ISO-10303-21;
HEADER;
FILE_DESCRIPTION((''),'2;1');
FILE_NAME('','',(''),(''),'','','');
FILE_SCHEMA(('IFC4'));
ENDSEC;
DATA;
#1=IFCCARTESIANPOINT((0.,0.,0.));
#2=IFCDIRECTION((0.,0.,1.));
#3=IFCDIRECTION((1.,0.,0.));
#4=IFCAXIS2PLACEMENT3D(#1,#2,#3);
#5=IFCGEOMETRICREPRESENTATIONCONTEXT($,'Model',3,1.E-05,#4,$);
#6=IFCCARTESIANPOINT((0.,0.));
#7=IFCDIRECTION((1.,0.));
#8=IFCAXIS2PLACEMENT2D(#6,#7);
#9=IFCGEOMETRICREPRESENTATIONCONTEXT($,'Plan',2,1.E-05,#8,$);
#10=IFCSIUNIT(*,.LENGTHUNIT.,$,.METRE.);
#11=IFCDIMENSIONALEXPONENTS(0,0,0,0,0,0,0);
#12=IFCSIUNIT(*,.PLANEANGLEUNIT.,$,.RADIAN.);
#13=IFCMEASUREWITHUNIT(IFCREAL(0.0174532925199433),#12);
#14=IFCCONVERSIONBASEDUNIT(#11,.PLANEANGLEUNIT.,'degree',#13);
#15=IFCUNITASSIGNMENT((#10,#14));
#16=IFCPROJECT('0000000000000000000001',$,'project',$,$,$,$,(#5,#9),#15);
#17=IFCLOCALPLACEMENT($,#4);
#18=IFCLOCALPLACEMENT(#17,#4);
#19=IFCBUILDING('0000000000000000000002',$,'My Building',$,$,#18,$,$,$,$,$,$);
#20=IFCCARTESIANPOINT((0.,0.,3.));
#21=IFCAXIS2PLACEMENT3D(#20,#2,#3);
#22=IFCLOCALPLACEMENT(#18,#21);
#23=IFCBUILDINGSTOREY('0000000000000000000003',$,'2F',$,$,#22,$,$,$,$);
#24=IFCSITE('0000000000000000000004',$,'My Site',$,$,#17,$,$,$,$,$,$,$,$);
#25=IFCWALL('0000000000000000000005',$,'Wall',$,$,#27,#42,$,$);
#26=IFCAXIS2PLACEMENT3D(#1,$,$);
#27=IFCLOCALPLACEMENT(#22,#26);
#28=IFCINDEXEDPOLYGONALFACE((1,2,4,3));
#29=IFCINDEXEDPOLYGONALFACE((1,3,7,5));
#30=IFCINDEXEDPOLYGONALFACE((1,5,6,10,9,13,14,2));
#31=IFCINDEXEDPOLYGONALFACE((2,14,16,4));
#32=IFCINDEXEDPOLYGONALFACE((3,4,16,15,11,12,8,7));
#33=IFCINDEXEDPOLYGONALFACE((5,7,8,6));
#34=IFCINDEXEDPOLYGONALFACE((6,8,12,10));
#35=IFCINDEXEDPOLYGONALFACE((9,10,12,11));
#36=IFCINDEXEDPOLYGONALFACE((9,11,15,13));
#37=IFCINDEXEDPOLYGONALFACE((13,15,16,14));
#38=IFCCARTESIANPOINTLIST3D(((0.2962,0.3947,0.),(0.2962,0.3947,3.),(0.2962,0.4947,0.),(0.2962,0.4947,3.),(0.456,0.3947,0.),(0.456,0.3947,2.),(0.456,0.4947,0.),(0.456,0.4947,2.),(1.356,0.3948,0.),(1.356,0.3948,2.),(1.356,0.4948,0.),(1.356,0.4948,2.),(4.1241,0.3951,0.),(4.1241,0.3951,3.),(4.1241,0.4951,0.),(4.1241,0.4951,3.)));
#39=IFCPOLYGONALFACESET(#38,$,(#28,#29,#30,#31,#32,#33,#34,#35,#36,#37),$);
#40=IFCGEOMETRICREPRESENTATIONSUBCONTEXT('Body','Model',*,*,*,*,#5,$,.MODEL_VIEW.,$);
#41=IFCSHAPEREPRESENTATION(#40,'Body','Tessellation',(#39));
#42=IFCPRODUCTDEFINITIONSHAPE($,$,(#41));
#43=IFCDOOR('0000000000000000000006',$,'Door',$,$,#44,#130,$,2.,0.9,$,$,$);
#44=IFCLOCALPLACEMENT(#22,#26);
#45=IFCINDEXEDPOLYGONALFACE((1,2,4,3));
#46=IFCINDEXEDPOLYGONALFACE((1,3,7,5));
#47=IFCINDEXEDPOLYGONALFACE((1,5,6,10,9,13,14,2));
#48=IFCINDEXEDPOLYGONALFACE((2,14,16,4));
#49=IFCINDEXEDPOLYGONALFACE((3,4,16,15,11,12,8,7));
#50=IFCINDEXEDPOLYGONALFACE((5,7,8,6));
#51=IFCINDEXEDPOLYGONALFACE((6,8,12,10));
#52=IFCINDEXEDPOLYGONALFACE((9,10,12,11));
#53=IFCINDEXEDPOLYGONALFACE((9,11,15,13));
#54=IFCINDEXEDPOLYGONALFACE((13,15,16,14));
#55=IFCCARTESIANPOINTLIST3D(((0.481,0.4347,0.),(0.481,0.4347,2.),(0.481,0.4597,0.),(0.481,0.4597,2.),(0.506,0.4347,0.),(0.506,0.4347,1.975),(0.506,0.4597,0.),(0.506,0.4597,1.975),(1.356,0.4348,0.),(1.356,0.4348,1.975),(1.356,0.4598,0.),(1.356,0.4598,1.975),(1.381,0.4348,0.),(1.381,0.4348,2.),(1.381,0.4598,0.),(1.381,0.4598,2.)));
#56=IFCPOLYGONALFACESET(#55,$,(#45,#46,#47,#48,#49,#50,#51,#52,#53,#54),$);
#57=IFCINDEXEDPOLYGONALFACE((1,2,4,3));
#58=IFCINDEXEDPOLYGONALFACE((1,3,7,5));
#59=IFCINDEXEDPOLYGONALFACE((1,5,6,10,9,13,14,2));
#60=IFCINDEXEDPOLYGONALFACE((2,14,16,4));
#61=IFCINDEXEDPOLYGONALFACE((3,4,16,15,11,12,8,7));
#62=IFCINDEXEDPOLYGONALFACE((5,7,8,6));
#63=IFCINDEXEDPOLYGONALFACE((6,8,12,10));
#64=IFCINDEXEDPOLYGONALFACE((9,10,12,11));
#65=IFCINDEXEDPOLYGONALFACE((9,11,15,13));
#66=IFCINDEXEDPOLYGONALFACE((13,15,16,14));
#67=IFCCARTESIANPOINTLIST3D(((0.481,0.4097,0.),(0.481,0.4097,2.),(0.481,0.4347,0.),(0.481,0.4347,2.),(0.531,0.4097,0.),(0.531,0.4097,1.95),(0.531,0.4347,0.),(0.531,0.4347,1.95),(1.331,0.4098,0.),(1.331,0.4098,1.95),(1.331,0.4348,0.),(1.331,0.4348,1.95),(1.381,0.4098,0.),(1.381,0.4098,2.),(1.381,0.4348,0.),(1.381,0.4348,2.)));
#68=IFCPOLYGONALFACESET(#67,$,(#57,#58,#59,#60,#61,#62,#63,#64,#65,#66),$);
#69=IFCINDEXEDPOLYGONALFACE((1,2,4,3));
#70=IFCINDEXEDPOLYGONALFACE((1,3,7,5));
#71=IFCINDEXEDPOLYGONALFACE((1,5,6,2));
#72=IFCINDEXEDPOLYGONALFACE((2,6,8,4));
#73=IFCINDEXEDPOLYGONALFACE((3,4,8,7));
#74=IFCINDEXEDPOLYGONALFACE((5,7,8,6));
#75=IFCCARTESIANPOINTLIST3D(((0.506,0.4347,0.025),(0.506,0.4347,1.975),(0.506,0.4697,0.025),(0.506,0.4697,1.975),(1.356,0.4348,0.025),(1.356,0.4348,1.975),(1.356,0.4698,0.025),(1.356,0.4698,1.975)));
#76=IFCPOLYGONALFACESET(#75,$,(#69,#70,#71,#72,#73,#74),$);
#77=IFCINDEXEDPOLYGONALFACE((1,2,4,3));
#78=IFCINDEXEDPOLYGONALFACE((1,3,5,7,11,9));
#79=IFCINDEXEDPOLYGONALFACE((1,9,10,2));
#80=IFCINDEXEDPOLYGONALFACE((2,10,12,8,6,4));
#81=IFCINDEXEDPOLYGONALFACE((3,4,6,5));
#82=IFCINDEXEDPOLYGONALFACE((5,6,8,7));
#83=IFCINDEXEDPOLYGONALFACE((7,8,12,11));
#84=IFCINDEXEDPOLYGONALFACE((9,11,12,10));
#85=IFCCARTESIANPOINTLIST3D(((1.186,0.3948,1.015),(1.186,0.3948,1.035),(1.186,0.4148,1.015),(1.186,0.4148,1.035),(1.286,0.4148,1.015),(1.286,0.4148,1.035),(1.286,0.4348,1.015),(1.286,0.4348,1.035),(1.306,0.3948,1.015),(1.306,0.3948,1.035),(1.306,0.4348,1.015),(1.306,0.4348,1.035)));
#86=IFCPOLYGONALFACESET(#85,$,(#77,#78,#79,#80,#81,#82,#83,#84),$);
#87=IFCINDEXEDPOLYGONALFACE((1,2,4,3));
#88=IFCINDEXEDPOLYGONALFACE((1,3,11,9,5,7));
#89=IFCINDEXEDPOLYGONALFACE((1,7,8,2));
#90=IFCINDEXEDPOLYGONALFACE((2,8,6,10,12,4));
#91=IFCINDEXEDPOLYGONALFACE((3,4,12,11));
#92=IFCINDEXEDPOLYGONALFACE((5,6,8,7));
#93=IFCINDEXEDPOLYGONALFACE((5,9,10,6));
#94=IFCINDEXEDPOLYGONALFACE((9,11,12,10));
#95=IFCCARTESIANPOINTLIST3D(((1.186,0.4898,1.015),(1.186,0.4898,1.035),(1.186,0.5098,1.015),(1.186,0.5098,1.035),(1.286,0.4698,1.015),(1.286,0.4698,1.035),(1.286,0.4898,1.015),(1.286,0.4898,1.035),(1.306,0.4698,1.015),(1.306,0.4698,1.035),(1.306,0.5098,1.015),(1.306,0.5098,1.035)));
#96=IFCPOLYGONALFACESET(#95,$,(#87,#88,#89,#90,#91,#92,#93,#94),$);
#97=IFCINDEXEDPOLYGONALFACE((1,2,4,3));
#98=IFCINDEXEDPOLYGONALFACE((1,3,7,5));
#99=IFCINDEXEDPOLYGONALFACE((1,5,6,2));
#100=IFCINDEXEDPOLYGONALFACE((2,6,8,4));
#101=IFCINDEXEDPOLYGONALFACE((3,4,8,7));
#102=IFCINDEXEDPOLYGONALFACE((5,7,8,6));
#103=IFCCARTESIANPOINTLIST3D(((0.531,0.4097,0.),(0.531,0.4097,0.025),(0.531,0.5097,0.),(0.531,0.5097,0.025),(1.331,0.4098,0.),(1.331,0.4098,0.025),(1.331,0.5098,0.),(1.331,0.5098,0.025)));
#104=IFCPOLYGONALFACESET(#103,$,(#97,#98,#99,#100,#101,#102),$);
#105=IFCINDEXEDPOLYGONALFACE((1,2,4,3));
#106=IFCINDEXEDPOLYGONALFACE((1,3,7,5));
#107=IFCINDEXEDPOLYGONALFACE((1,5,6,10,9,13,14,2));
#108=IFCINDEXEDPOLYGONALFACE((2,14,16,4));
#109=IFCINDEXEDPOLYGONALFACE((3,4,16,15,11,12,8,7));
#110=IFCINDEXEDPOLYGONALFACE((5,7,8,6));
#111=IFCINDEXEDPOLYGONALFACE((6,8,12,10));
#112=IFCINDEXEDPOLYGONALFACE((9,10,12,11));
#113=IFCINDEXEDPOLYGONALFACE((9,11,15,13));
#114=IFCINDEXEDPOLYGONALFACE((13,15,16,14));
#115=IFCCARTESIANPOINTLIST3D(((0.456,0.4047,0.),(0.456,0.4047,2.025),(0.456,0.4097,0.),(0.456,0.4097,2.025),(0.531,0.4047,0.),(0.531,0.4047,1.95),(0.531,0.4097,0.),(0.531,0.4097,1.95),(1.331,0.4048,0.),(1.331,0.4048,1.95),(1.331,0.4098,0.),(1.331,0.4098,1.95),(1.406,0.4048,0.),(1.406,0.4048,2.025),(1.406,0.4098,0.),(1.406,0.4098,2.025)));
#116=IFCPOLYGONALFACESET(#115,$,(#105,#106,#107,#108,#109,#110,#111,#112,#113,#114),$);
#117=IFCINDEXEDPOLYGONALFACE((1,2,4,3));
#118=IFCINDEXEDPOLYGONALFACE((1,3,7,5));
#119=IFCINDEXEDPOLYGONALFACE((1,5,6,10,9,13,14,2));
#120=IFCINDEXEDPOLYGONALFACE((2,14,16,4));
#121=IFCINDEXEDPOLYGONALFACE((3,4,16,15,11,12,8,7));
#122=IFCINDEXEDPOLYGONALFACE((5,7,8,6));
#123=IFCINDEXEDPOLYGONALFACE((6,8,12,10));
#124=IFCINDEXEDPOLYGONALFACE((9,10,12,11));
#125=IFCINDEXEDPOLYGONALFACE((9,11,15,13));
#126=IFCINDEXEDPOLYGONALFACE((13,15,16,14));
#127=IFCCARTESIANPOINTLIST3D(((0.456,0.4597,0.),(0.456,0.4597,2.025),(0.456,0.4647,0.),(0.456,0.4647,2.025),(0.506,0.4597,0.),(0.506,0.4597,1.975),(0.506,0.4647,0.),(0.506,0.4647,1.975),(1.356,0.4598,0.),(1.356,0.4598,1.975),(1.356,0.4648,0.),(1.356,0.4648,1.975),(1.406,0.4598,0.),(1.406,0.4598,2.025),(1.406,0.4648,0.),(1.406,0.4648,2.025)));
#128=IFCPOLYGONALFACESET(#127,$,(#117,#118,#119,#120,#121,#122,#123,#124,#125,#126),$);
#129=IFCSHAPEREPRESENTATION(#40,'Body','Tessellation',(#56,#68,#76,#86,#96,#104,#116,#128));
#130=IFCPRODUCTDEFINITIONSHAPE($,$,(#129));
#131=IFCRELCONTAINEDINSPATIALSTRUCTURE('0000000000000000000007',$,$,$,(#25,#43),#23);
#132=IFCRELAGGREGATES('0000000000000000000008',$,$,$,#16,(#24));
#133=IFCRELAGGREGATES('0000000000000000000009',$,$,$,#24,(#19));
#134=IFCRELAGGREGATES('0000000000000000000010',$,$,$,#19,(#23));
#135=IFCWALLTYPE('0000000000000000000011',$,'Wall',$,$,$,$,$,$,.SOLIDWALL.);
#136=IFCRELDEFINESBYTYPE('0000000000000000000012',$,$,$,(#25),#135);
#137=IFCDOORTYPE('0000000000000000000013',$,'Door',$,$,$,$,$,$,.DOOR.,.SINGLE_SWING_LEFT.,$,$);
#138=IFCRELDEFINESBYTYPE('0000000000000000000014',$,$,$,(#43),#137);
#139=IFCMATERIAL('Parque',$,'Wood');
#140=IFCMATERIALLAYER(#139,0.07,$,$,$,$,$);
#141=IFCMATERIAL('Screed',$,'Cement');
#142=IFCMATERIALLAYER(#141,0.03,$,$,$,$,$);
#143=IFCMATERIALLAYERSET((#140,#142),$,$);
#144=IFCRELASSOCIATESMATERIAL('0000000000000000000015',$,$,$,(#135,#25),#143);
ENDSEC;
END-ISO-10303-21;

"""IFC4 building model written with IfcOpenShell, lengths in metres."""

from ifc_helpers import new_model, entity, si_unit, converted_unit, frame, origin_with_axes, origin_2d_with_axis, place, context, subcontext, project, spatial, line, indexed_curve, outline, extrude, shape, source, transform, mapped, material, layer, layer_set, layer_usage, type_object, type_shapes, element, fill, save


model = new_model("IFC4")

# Units and contexts
model_context = context("Model", 3, precision=1e-05, world=origin_with_axes())
plan_context = context("Plan", 2, precision=1e-05, world=origin_2d_with_axis())
body_context_1 = subcontext(model_context, "Body", "Model", "MODEL_VIEW")
body_context_2 = subcontext(plan_context, "Body", "Plan", "PLAN_VIEW")
ifc_project = project(units=[si_unit("LENGTHUNIT", "METRE"), converted_unit("PLANEANGLEUNIT", "degree", entity("IfcReal", 0.0174532925199433), si_unit("PLANEANGLEUNIT", "RADIAN"), dimensions=[0, 0, 0, 0, 0, 0, 0])], contexts=[model_context, plan_context])

# Site, building, storey
site_placement = place(None, origin_with_axes())
site = spatial("IfcSite", under=ifc_project, at=site_placement, Name="My Site")
building_placement = place(site_placement, origin_with_axes())
building = spatial("IfcBuilding", under=site, at=building_placement, Name="My Building")
storey_placement = place(building_placement, frame((0.0, 0.0, 3.0), z_axis=(0.0, 0.0, 1.0), x_axis=(1.0, 0.0, 0.0)))
storey = spatial("IfcBuildingStorey", under=building, at=storey_placement, Name="2F")

# Shared definitions
ifc_material_1 = material(Name="Parque", Category="Wood")
ifc_layer_1 = layer(ifc_material_1, 0.07)
ifc_material_2 = material(Name="Screed", Category="Cement")
ifc_layer_2 = layer(ifc_material_2, 0.03)
ifc_layer_set_1 = layer_set([ifc_layer_1, ifc_layer_2])
wall_type = type_object("IfcWallType", Name="Wall", PredefinedType="SOLIDWALL", material=ifc_layer_set_1)

# Shared definitions
shared_shape_1 = source(origin_with_axes(), body_context_1, "Body", "SweptSolid", [
    extrude(outline(indexed_curve([(0.0, 0.0), (0.9, 0.0), (0.9, 2.0), (0.0, 2.0)], segments=[line(1, 2, 3, 4, 1)])), frame((0.0, -0.6, 0.0), z_axis=(0.0, -1.0, 0.0), x_axis=(1.0, 0.0, 0.0)), (0.0, 0.0, -1.0), 1.2),
])
door_type_1 = type_object("IfcDoorType", Name="Door", OperationType="SINGLE_SWING_LEFT", PredefinedType="DOOR")
shared_shape_2 = source(origin_with_axes(), body_context_1, "Body", "SweptSolid", [
    extrude(outline(indexed_curve([(0.0, 0.0), (0.0, 2.0), (0.9, 2.0), (0.9, 0.0), (0.875, 0.0), (0.875, 1.975), (0.025, 1.975), (0.025, 0.0)], segments=[line(1, 2, 3, 4, 5, 6, 7, 8, 1)])), frame((0.0, 0.025, 0.0), z_axis=(0.0, -1.0, 0.0), x_axis=(1.0, 0.0, 0.0)), (0.0, 0.0, -1.0), 0.025),
    extrude(outline(indexed_curve([(0.0, 0.0), (0.0, 2.0), (0.9, 2.0), (0.9, 0.0), (0.85, 0.0), (0.85, 1.95), (0.05, 1.95), (0.05, 0.0)], segments=[line(1, 2, 3, 4, 5, 6, 7, 8, 1)])), frame((0.0, 0.0, 0.0), z_axis=(0.0, -1.0, 0.0), x_axis=(1.0, 0.0, 0.0)), (0.0, 0.0, -1.0), 0.025),
    extrude(outline(indexed_curve([(0.0, 0.0), (0.85, 0.0), (0.85, 0.035), (0.0, 0.035)], segments=[line(1, 2, 3, 4, 1)])), frame((0.025, 0.025, 0.025), z_axis=(0.0, 0.0, 1.0), x_axis=(1.0, 0.0, 0.0)), (0.0, 0.0, 1.0), 1.95),
    extrude(outline(indexed_curve([(0.0, 0.0), (0.0, -0.04), (-0.12, -0.04), (-0.12, -0.02), (-0.02, -0.02), (-0.02, 0.0)], segments=[line(1, 2, 3, 4, 5, 6, 1)])), frame((0.825, 0.025, 1.015), z_axis=(0.0, 0.0, 1.0), x_axis=(1.0, 0.0, 0.0)), (0.0, 0.0, 1.0), 0.02),
    extrude(outline(indexed_curve([(0.0, 0.0), (0.0, 0.04), (-0.12, 0.04), (-0.12, 0.02), (-0.02, 0.02), (-0.02, 0.0)], segments=[line(1, 2, 3, 4, 5, 6, 1)])), frame((0.825, 0.06, 1.015), z_axis=(0.0, 0.0, 1.0), x_axis=(1.0, 0.0, 0.0)), (0.0, 0.0, 1.0), 0.02),
    extrude(outline(indexed_curve([(0.0, 0.0), (0.8, 0.0), (0.8, 0.1), (0.0, 0.1)], segments=[line(1, 2, 3, 4, 1)])), frame((0.05, 0.0, 0.0), z_axis=(0.0, 0.0, 1.0), x_axis=(1.0, 0.0, 0.0)), (0.0, 0.0, 1.0), 0.025),
    extrude(outline(indexed_curve([(0.0, 0.0), (0.0, 2.025), (0.95, 2.025), (0.95, 0.0), (0.875, 0.0), (0.875, 1.95), (0.075, 1.95), (0.075, 0.0)], segments=[line(1, 2, 3, 4, 5, 6, 7, 8, 1)])), frame((-0.025, -0.005, 0.0), z_axis=(0.0, -1.0, 0.0), x_axis=(1.0, 0.0, 0.0)), (0.0, 0.0, -1.0), 0.005),
    extrude(outline(indexed_curve([(0.0, 0.0), (0.0, 2.025), (0.95, 2.025), (0.95, 0.0), (0.9, 0.0), (0.9, 1.975), (0.05, 1.975), (0.05, 0.0)], segments=[line(1, 2, 3, 4, 5, 6, 7, 8, 1)])), frame((-0.025, 0.05, 0.0), z_axis=(0.0, -1.0, 0.0), x_axis=(1.0, 0.0, 0.0)), (0.0, 0.0, -1.0), 0.005),
])
shared_shape_3 = source(origin_with_axes(), body_context_2, "Body", "Curve2D", [
    entity("IfcIndexedPolyCurve", entity("IfcCartesianPointList2D", [[0.0, 0.0], [0.0, 0.05], [0.025, 0.05], [0.025, 0.025], [0.05, 0.025], [0.05, 0.0]]), [entity("IfcLineIndex", [1, 2, 3, 4, 5, 6, 1])]),
    entity("IfcIndexedPolyCurve", entity("IfcCartesianPointList2D", [[0.9, 0.0], [0.9, 0.05], [0.875, 0.05], [0.875, 0.025], [0.85, 0.025], [0.85, 0.0]]), [entity("IfcLineIndex", [1, 2, 3, 4, 5, 6, 1])]),
    entity("IfcTrimmedCurve", entity("IfcEllipse", entity("IfcAxis2Placement2D", entity("IfcCartesianPoint", [0.06, 0.05]), entity("IfcDirection", [1.0, 0.0])), 0.815, 0.85), [entity("IfcCartesianPoint", [0.875, 0.05])], [entity("IfcCartesianPoint", [0.06, 0.9])], True, "CARTESIAN"),
    entity("IfcIndexedPolyCurve", entity("IfcCartesianPointList2D", [[0.025, 0.05], [0.06, 0.05], [0.06, 0.9], [0.025, 0.9]]), [entity("IfcLineIndex", [1, 2, 3, 4, 1])]),
])
type_shapes(door_type_1, [shared_shape_2, shared_shape_3])

# Wall, opening, door
ifc_layer_usage_1 = layer_usage(ifc_layer_set_1, "AXIS2", "POSITIVE", 0.0)
wall_1_placement = place(storey_placement, frame((4.1241, 0.4951, 0.0), z_axis=(0.0, 0.0, 1.0), x_axis=(-1.0, -0.000094, 0.0)))
wall_1 = element("IfcWall", 1, at=wall_1_placement, inside=storey, type_object=wall_type, material=ifc_layer_usage_1, Name="Wall", context=body_context_1, shape_type="SweptSolid", body=[
    extrude(outline(indexed_curve([(0.0, 0.0), (0.0, 0.1), (3.8279, 0.1), (3.8279, 0.0)], segments=[line(1, 2, 3, 4, 1)])), origin_with_axes(), (0.0, 0.0, 1.0), 3.0),
])
opening_1_placement = place(wall_1_placement, frame((2.7681, 0.0, 0.0), z_axis=(0.0, 0.0, 1.0), x_axis=(1.0, 0.0, 0.0)))
opening_1 = element("IfcOpeningElement", 2, at=opening_1_placement, cuts=wall_1, PredefinedType="OPENING", context=body_context_1, shape_type="MappedRepresentation", body=[
    mapped(shared_shape_1, transform((0.0, 0.0, 0.0), x_axis=(1.0, 0.0, 0.0), y_axis=(0.0, 1.0, 0.0), z_axis=(0.0, 0.0, 1.0), scale=1.0)),
])
door_1_placement = place(opening_1_placement, frame((0.875, 0.085, 0.0), z_axis=(0.0, 0.0, 1.0), x_axis=(-1.0, 0.0, 0.0)))
door_1 = element("IfcDoor", 3, at=door_1_placement, inside=storey, type_object=door_type_1, Name="Door", OverallHeight=2.0, OverallWidth=0.9, shapes=[
    shape(body_context_1, "Body", "MappedRepresentation", [mapped(shared_shape_2, transform((0.0, 0.0, 0.0), x_axis=(1.0, 0.0, 0.0), y_axis=(0.0, 1.0, 0.0), z_axis=(0.0, 0.0, 1.0), scale=1.0))]),
    shape(body_context_2, "Body", "MappedRepresentation", [mapped(shared_shape_3, transform((0.0, 0.0, 0.0), x_axis=(1.0, 0.0, 0.0), y_axis=(0.0, 1.0, 0.0), z_axis=(0.0, 0.0, 1.0), scale=1.0))]),
])
fill(opening_1, door_1)

save(model, "model.ifc")
